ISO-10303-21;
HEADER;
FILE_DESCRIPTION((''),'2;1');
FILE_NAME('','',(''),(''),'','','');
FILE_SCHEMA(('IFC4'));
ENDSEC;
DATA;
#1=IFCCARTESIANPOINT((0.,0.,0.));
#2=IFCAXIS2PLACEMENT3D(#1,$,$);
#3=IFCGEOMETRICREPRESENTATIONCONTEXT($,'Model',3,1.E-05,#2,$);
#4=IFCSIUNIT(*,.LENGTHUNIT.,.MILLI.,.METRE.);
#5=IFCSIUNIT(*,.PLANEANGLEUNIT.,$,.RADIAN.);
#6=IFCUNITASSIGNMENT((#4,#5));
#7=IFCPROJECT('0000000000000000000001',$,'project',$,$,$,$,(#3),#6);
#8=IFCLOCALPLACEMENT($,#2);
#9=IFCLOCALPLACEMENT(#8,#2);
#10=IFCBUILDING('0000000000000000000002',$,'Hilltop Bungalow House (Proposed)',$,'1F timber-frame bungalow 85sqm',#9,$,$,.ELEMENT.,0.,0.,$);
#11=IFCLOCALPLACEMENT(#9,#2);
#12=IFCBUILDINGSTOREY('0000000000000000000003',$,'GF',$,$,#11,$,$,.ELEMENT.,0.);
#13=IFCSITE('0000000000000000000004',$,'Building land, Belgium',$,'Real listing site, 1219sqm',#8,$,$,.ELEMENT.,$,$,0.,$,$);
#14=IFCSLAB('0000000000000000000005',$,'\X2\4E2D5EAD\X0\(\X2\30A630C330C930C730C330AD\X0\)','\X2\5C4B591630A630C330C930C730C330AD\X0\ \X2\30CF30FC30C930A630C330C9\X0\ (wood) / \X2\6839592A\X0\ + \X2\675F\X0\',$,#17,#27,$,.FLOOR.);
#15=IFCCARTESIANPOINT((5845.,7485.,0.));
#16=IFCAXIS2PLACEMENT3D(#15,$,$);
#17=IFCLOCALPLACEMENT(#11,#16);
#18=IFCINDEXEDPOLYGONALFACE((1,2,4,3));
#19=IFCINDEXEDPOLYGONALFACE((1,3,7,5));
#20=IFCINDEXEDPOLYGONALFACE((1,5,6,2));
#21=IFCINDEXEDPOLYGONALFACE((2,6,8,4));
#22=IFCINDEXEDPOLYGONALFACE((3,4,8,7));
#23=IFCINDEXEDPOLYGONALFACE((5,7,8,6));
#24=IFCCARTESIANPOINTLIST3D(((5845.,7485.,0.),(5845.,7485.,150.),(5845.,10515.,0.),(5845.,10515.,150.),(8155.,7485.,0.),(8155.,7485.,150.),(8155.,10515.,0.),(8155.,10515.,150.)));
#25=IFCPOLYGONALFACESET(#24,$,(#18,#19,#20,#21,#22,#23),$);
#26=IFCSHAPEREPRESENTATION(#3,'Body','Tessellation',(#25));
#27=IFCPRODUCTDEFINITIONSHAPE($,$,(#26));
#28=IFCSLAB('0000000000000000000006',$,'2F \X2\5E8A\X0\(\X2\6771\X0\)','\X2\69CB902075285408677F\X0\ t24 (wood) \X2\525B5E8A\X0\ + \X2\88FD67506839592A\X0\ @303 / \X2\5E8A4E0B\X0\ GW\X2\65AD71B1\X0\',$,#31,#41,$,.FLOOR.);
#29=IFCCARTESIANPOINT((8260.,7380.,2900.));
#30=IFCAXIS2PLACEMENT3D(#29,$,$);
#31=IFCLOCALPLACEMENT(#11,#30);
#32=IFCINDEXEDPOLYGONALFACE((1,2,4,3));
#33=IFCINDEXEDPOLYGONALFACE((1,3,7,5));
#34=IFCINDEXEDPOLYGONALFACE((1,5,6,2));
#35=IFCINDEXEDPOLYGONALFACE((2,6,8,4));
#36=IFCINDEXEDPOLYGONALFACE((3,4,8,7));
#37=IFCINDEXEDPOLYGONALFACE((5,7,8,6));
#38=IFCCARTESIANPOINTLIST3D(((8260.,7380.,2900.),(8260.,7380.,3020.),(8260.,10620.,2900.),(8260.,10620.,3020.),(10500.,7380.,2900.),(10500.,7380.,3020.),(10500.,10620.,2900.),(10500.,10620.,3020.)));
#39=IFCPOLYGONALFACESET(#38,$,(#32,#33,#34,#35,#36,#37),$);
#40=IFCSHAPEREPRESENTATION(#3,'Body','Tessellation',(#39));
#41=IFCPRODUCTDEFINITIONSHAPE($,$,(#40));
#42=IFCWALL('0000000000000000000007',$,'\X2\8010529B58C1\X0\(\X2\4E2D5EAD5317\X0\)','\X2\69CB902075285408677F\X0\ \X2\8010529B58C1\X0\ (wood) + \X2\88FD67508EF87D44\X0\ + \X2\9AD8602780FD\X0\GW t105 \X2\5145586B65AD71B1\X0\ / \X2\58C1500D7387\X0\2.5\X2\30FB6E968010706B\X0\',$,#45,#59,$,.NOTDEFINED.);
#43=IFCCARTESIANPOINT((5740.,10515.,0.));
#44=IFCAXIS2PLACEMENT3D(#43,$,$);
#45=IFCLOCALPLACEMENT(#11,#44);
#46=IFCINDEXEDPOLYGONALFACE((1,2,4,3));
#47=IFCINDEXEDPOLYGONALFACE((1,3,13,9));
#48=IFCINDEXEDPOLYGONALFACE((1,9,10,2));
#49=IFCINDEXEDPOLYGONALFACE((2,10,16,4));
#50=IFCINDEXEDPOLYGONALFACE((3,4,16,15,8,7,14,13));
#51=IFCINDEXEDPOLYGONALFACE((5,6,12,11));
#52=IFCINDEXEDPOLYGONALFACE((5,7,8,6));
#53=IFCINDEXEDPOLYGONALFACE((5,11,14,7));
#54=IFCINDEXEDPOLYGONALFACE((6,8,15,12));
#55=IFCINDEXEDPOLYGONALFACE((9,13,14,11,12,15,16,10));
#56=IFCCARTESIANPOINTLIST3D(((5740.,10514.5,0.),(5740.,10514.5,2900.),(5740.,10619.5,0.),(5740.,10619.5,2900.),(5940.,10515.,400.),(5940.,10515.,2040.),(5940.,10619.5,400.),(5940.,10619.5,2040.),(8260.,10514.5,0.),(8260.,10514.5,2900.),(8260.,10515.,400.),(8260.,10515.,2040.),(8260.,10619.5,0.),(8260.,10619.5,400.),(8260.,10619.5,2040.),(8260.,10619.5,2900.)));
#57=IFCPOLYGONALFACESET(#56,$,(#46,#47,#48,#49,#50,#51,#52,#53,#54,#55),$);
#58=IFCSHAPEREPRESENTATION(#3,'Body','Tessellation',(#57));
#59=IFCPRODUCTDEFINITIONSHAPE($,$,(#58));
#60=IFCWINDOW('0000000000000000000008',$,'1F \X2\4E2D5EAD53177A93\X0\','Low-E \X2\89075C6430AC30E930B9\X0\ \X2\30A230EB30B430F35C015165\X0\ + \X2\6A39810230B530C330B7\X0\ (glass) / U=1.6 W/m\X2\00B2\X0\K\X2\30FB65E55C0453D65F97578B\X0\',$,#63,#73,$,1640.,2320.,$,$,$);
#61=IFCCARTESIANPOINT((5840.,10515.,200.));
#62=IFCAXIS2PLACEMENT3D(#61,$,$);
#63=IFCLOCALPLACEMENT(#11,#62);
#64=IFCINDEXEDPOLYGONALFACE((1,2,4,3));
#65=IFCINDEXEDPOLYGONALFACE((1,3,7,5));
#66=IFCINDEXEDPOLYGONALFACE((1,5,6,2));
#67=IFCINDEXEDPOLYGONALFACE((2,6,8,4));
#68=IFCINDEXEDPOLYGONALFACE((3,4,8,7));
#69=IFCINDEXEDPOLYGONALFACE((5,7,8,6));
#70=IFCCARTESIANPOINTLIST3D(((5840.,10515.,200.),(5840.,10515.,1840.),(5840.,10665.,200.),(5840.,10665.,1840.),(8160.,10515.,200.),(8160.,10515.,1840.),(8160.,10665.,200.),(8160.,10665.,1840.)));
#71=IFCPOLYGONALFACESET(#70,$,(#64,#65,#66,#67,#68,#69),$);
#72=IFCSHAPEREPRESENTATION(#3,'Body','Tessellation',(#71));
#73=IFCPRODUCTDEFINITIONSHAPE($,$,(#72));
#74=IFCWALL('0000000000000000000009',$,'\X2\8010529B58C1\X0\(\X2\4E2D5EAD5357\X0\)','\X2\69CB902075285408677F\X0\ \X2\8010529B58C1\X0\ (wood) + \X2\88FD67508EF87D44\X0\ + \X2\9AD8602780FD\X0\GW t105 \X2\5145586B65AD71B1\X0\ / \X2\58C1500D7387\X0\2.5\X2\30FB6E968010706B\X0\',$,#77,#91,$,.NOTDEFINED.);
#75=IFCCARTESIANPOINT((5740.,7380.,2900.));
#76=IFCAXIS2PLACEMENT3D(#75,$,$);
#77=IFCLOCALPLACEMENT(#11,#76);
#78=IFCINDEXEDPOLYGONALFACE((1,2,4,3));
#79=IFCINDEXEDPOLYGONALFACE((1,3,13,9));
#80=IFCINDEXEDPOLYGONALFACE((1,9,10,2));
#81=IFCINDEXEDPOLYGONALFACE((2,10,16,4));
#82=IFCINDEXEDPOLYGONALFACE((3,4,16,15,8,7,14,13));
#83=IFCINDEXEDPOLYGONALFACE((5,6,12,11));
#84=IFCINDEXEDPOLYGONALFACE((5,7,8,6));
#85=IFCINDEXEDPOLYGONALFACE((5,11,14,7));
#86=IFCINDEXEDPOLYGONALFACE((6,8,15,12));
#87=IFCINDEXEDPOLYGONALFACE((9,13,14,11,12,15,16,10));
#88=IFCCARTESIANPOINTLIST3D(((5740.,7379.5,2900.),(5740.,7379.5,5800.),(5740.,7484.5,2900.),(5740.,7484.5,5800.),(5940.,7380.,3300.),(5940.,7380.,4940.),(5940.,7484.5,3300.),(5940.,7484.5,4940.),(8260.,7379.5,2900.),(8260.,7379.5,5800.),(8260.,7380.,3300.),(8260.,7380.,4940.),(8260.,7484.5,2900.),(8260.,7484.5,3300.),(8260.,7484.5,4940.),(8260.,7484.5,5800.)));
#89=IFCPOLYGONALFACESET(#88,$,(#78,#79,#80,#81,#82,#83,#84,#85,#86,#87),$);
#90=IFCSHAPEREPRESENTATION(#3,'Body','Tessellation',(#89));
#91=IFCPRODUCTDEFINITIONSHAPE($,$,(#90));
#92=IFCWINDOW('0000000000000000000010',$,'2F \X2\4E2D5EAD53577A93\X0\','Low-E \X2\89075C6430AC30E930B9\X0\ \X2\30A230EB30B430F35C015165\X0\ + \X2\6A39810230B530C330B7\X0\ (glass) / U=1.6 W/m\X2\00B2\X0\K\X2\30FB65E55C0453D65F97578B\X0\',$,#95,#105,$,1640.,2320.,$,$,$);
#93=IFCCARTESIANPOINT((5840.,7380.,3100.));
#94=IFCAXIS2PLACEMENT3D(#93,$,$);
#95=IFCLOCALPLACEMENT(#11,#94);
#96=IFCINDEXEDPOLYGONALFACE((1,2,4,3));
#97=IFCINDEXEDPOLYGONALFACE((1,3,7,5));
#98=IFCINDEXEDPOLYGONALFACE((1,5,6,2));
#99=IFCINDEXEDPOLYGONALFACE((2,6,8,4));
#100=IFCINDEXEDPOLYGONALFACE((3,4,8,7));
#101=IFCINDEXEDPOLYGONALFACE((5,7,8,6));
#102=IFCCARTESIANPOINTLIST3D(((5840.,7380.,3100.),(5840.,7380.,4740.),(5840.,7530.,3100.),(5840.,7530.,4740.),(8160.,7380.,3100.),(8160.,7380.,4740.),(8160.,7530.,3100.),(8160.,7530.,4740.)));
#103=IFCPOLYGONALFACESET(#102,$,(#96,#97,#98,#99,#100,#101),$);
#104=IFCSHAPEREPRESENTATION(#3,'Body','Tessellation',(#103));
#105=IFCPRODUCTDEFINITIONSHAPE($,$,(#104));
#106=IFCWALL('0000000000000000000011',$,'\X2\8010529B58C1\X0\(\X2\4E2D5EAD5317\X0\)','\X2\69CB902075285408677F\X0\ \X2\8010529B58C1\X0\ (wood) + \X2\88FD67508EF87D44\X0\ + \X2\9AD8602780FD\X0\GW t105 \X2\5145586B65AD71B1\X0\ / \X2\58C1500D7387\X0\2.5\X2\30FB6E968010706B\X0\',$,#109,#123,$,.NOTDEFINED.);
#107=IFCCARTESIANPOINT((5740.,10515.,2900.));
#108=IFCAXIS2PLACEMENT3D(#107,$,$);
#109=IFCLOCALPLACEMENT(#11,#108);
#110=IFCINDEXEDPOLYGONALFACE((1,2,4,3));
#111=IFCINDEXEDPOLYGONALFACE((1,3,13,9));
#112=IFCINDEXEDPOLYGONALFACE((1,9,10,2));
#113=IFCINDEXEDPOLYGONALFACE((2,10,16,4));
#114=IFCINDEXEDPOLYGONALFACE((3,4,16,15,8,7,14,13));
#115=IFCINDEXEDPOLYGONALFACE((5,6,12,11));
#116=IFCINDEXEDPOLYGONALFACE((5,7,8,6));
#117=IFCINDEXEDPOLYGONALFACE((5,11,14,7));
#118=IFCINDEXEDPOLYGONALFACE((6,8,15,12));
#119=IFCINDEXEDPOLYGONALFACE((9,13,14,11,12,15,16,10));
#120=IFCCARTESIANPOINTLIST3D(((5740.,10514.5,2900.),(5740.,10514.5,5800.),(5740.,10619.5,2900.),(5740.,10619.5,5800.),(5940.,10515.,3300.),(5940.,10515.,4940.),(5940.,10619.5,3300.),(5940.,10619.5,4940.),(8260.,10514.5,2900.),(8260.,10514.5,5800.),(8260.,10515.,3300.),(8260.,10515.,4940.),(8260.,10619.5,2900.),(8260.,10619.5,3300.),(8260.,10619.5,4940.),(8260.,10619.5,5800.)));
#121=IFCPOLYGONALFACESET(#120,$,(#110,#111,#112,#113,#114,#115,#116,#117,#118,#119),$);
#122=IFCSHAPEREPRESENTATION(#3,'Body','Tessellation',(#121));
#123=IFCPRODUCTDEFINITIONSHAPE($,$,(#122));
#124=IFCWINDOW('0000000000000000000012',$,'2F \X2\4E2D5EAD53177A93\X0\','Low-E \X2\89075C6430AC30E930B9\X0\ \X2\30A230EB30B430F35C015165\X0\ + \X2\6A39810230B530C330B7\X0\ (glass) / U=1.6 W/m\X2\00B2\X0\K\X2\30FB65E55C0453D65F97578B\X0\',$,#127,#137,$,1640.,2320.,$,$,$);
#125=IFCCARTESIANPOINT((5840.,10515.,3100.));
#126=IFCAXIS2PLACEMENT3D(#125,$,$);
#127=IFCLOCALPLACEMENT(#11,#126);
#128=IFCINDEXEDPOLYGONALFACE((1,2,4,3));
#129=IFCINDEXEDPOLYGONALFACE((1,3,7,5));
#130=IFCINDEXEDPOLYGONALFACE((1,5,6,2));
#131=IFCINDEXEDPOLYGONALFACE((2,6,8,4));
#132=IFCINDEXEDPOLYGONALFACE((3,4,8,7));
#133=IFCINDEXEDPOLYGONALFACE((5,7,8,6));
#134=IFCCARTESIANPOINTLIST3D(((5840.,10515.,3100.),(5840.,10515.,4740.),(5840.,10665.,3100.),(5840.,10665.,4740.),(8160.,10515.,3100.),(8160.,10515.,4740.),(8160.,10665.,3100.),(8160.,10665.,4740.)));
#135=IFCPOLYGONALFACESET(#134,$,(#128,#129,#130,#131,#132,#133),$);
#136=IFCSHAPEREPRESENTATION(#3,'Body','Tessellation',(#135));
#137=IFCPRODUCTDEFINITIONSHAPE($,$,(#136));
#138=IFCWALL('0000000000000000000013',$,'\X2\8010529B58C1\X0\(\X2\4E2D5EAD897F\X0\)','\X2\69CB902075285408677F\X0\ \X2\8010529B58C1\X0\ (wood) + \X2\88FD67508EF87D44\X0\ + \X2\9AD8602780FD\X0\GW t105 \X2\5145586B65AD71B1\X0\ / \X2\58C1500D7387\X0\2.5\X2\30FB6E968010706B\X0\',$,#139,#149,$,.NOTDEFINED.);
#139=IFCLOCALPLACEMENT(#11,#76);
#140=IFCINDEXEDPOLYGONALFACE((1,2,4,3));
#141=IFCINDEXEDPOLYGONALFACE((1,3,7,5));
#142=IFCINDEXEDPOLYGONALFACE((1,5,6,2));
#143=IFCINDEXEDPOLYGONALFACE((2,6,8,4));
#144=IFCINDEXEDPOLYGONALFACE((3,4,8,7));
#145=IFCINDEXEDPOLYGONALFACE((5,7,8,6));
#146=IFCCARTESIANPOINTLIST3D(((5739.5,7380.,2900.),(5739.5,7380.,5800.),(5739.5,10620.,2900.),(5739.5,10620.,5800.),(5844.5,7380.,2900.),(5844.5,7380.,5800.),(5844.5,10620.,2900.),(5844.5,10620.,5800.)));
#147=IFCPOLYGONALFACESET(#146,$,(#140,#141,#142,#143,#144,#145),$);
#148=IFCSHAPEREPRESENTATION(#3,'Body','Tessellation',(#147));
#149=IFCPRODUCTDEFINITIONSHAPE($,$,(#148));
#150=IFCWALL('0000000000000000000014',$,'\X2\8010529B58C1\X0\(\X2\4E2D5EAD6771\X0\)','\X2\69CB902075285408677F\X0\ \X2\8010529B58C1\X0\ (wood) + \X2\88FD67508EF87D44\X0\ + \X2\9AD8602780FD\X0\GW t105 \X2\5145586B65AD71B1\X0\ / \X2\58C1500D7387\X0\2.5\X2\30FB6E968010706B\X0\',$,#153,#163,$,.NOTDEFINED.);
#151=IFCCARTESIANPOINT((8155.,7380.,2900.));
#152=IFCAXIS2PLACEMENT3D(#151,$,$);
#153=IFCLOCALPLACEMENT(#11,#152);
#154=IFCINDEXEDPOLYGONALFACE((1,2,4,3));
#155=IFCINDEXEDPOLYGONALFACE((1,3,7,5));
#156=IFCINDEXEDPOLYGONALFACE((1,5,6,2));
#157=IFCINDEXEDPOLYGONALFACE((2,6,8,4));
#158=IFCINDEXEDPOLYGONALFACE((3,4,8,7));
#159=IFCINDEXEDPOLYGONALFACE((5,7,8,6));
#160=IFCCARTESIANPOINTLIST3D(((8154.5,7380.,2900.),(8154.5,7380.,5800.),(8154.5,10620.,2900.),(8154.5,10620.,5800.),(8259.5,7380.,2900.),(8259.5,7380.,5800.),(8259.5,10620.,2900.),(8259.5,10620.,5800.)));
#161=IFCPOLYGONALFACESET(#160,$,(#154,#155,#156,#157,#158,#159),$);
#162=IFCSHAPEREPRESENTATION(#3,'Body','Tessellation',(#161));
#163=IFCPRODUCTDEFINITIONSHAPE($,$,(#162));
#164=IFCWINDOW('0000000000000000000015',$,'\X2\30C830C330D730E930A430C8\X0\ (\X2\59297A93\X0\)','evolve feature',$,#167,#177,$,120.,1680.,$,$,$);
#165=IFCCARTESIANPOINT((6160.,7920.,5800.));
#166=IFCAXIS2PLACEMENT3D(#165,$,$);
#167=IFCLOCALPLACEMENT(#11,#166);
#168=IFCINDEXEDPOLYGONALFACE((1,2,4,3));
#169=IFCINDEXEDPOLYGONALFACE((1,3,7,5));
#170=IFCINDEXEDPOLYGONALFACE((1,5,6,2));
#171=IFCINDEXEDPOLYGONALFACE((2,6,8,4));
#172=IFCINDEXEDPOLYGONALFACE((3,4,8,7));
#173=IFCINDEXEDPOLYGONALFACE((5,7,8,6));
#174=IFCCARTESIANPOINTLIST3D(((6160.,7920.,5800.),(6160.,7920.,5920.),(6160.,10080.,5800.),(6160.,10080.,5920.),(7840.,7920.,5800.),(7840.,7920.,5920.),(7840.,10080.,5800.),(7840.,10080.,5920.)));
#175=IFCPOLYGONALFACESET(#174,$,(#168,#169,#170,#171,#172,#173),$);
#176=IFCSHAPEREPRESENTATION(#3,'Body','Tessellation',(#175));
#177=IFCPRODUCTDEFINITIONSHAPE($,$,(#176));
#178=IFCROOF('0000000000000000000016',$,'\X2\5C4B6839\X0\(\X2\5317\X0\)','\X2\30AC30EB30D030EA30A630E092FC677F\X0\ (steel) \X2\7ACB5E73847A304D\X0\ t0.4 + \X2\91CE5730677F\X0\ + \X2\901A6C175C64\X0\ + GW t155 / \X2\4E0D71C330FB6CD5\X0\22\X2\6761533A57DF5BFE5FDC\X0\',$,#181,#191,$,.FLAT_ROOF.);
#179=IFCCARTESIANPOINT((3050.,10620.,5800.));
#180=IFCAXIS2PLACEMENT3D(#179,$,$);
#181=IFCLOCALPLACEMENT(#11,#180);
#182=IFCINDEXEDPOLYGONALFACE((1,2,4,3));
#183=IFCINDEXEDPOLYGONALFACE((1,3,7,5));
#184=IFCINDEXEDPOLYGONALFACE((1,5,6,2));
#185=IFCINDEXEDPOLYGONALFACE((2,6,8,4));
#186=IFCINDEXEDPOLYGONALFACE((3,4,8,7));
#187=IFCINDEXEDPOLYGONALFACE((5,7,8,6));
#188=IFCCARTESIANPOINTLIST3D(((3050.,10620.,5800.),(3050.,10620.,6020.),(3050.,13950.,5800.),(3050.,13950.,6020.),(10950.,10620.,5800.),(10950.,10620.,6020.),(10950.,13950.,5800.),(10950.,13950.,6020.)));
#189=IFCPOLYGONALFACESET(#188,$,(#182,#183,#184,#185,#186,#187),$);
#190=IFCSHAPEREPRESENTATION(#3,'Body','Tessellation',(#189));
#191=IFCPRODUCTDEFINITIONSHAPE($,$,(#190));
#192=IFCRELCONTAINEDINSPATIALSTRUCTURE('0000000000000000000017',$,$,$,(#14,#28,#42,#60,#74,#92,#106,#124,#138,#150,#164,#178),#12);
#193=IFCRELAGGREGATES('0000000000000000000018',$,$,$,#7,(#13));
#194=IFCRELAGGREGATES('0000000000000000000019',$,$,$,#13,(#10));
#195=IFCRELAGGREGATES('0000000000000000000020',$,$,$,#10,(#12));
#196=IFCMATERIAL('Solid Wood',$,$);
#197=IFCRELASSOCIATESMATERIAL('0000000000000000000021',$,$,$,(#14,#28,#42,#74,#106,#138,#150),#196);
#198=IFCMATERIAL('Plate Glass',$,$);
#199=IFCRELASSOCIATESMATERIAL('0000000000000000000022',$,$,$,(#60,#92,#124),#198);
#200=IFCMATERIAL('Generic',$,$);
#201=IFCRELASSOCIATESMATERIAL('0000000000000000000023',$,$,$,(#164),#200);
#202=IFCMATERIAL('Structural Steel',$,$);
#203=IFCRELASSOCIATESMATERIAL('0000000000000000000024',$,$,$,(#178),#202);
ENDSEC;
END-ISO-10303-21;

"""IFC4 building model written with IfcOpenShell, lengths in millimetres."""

from ifc_helpers import new_model, si_unit, frame, frame_2d, origin, place, context, project, spatial, rectangle, extrude, material, element, fill, save


model = new_model("IFC4")

# Units and contexts
model_context = context("Model", 3, precision=1e-05, world=origin())
ifc_project = project(units=[si_unit("LENGTHUNIT", "METRE", prefix="MILLI"), si_unit("PLANEANGLEUNIT", "RADIAN")], contexts=[model_context])

# Site, building, storey
site_placement = place(None, origin())
site = spatial("IfcSite", under=ifc_project, at=site_placement, Name="Building land, Belgium", ObjectType="Real listing site, 1219sqm", CompositionType="ELEMENT", RefElevation=0.0)
building_placement = place(site_placement, origin())
building = spatial("IfcBuilding", under=site, at=building_placement, Name="Hilltop Bungalow House (Proposed)", ObjectType="1F timber-frame bungalow 85sqm", CompositionType="ELEMENT", ElevationOfRefHeight=0.0, ElevationOfTerrain=0.0)
storey_placement = place(building_placement, origin())
storey = spatial("IfcBuildingStorey", under=building, at=storey_placement, Name="GF", CompositionType="ELEMENT", Elevation=0.0)

# Slabs
ifc_material_1 = material(Name="Solid Wood")
slab_1_placement = place(storey_placement, frame((5845.0, 7485.0, 0.0)))
element("IfcSlab", 1, at=slab_1_placement, inside=storey, material=ifc_material_1, Name="中庭(ウッドデッキ)", Description="屋外ウッドデッキ ハードウッド (wood) / 根太 + 束", PredefinedType="FLOOR", context=model_context, shape_type="SweptSolid", body=[
    extrude(rectangle(XDim=2310.0, YDim=3030.0, at=frame_2d((1155.0, 1515.0))), frame((5845.0, 7485.0, 0.0)), (0.0, 0.0, 1.0), 150.0),
])
slab_2_placement = place(storey_placement, frame((8260.0, 7380.0, 2900.0)))
element("IfcSlab", 2, at=slab_2_placement, inside=storey, material=ifc_material_1, Name="2F 床(東)", Description="構造用合板 t24 (wood) 剛床 + 製材根太 @303 / 床下 GW断熱", PredefinedType="FLOOR", context=model_context, shape_type="SweptSolid", body=[
    extrude(rectangle(XDim=2240.0, YDim=3240.0, at=frame_2d((1120.0, 1620.0))), frame((8260.0, 7380.0, 2900.0)), (0.0, 0.0, 1.0), 120.0),
])

# Walls, openings, windows
wall_1_placement = place(storey_placement, frame((5740.0, 10515.0, 0.0)))
wall_1 = element("IfcWall", 3, at=wall_1_placement, inside=storey, material=ifc_material_1, Name="耐力壁(中庭北)", Description="構造用合板 耐力壁 (wood) + 製材軸組 + 高性能GW t105 充填断熱 / 壁倍率2.5・準耐火", PredefinedType="NOTDEFINED", context=model_context, shape_type="SweptSolid", body=[
    extrude(rectangle(XDim=2520.0, YDim=105.0, at=frame_2d((1260.0, 52.0))), frame((5740.0, 10515.0, 0.0)), (0.0, 0.0, 1.0), 2900.0),
])
opening_1_placement = place(storey_placement, frame((5840.0, 10515.0, 200.0)))
opening_1 = element("IfcOpeningElement", 4, at=opening_1_placement, cuts=wall_1, PredefinedType="NOTDEFINED", context=model_context, shape_type="SweptSolid", body=[
    extrude(rectangle(XDim=2320.0, YDim=150.0, at=frame_2d((1160.0, 75.0))), frame((5840.0, 10515.0, 200.0)), (0.0, 0.0, 1.0), 1640.0),
])
ifc_material_2 = material(Name="Plate Glass")
window_1_placement = place(storey_placement, frame((5840.0, 10515.0, 200.0)))
window_1 = element("IfcWindow", 5, at=window_1_placement, inside=storey, material=ifc_material_2, Name="1F 中庭北窓", Description="Low-E 複層ガラス アルゴン封入 + 樹脂サッシ (glass) / U=1.6 W/m²K・日射取得型", OverallHeight=1640.0, OverallWidth=2320.0, context=model_context, shape_type="SweptSolid", body=[
    extrude(rectangle(XDim=2320.0, YDim=150.0, at=frame_2d((1160.0, 75.0))), frame((5840.0, 10515.0, 200.0)), (0.0, 0.0, 1.0), 1640.0),
])
fill(opening_1, window_1)
wall_2_placement = place(storey_placement, frame((5740.0, 7380.0, 2900.0)))
wall_2 = element("IfcWall", 6, at=wall_2_placement, inside=storey, material=ifc_material_1, Name="耐力壁(中庭南)", Description="構造用合板 耐力壁 (wood) + 製材軸組 + 高性能GW t105 充填断熱 / 壁倍率2.5・準耐火", PredefinedType="NOTDEFINED", context=model_context, shape_type="SweptSolid", body=[
    extrude(rectangle(XDim=2520.0, YDim=105.0, at=frame_2d((1260.0, 52.0))), frame((5740.0, 7380.0, 2900.0)), (0.0, 0.0, 1.0), 2900.0),
])
opening_2_placement = place(storey_placement, frame((5840.0, 7380.0, 3100.0)))
opening_2 = element("IfcOpeningElement", 7, at=opening_2_placement, cuts=wall_2, PredefinedType="NOTDEFINED", context=model_context, shape_type="SweptSolid", body=[
    extrude(rectangle(XDim=2320.0, YDim=150.0, at=frame_2d((1160.0, 75.0))), frame((5840.0, 7380.0, 3100.0)), (0.0, 0.0, 1.0), 1640.0),
])
window_2_placement = place(storey_placement, frame((5840.0, 7380.0, 3100.0)))
window_2 = element("IfcWindow", 8, at=window_2_placement, inside=storey, material=ifc_material_2, Name="2F 中庭南窓", Description="Low-E 複層ガラス アルゴン封入 + 樹脂サッシ (glass) / U=1.6 W/m²K・日射取得型", OverallHeight=1640.0, OverallWidth=2320.0, context=model_context, shape_type="SweptSolid", body=[
    extrude(rectangle(XDim=2320.0, YDim=150.0, at=frame_2d((1160.0, 75.0))), frame((5840.0, 7380.0, 3100.0)), (0.0, 0.0, 1.0), 1640.0),
])
fill(opening_2, window_2)
wall_3_placement = place(storey_placement, frame((5740.0, 10515.0, 2900.0)))
wall_3 = element("IfcWall", 9, at=wall_3_placement, inside=storey, material=ifc_material_1, Name="耐力壁(中庭北)", Description="構造用合板 耐力壁 (wood) + 製材軸組 + 高性能GW t105 充填断熱 / 壁倍率2.5・準耐火", PredefinedType="NOTDEFINED", context=model_context, shape_type="SweptSolid", body=[
    extrude(rectangle(XDim=2520.0, YDim=105.0, at=frame_2d((1260.0, 52.0))), frame((5740.0, 10515.0, 2900.0)), (0.0, 0.0, 1.0), 2900.0),
])
opening_3_placement = place(storey_placement, frame((5840.0, 10515.0, 3100.0)))
opening_3 = element("IfcOpeningElement", 10, at=opening_3_placement, cuts=wall_3, PredefinedType="NOTDEFINED", context=model_context, shape_type="SweptSolid", body=[
    extrude(rectangle(XDim=2320.0, YDim=150.0, at=frame_2d((1160.0, 75.0))), frame((5840.0, 10515.0, 3100.0)), (0.0, 0.0, 1.0), 1640.0),
])
window_3_placement = place(storey_placement, frame((5840.0, 10515.0, 3100.0)))
window_3 = element("IfcWindow", 11, at=window_3_placement, inside=storey, material=ifc_material_2, Name="2F 中庭北窓", Description="Low-E 複層ガラス アルゴン封入 + 樹脂サッシ (glass) / U=1.6 W/m²K・日射取得型", OverallHeight=1640.0, OverallWidth=2320.0, context=model_context, shape_type="SweptSolid", body=[
    extrude(rectangle(XDim=2320.0, YDim=150.0, at=frame_2d((1160.0, 75.0))), frame((5840.0, 10515.0, 3100.0)), (0.0, 0.0, 1.0), 1640.0),
])
fill(opening_3, window_3)

# Walls
wall_4_placement = place(storey_placement, frame((5740.0, 7380.0, 2900.0)))
element("IfcWall", 12, at=wall_4_placement, inside=storey, material=ifc_material_1, Name="耐力壁(中庭西)", Description="構造用合板 耐力壁 (wood) + 製材軸組 + 高性能GW t105 充填断熱 / 壁倍率2.5・準耐火", PredefinedType="NOTDEFINED", context=model_context, shape_type="SweptSolid", body=[
    extrude(rectangle(XDim=105.0, YDim=3240.0, at=frame_2d((52.0, 1620.0))), frame((5740.0, 7380.0, 2900.0)), (0.0, 0.0, 1.0), 2900.0),
])
wall_5_placement = place(storey_placement, frame((8155.0, 7380.0, 2900.0)))
element("IfcWall", 13, at=wall_5_placement, inside=storey, material=ifc_material_1, Name="耐力壁(中庭東)", Description="構造用合板 耐力壁 (wood) + 製材軸組 + 高性能GW t105 充填断熱 / 壁倍率2.5・準耐火", PredefinedType="NOTDEFINED", context=model_context, shape_type="SweptSolid", body=[
    extrude(rectangle(XDim=105.0, YDim=3240.0, at=frame_2d((52.0, 1620.0))), frame((8155.0, 7380.0, 2900.0)), (0.0, 0.0, 1.0), 2900.0),
])

# Window
ifc_material_3 = material(Name="Generic")
window_4_placement = place(storey_placement, frame((6160.0, 7920.0, 5800.0)))
element("IfcWindow", 14, at=window_4_placement, inside=storey, material=ifc_material_3, Name="トップライト (天窓)", Description="evolve feature", OverallHeight=120.0, OverallWidth=1680.0, context=model_context, shape_type="SweptSolid", body=[
    extrude(rectangle(XDim=1680.0, YDim=2160.0, at=frame_2d((840.0, 1080.0))), frame((6160.0, 7920.0, 5800.0)), (0.0, 0.0, 1.0), 120.0),
])

# Roof
ifc_material_4 = material(Name="Structural Steel")
roof_1_placement = place(storey_placement, frame((3050.0, 10620.0, 5800.0)))
element("IfcRoof", 15, at=roof_1_placement, inside=storey, material=ifc_material_4, Name="屋根(北)", Description="ガルバリウム鋼板 (steel) 立平葺き t0.4 + 野地板 + 通気層 + GW t155 / 不燃・法22条区域対応", PredefinedType="FLAT_ROOF", context=model_context, shape_type="SweptSolid", body=[
    extrude(rectangle(XDim=7900.0, YDim=3330.0, at=frame_2d((3950.0, 1665.0))), frame((3050.0, 10620.0, 5800.0)), (0.0, 0.0, 1.0), 220.0),
])

save(model, "model.ifc")
